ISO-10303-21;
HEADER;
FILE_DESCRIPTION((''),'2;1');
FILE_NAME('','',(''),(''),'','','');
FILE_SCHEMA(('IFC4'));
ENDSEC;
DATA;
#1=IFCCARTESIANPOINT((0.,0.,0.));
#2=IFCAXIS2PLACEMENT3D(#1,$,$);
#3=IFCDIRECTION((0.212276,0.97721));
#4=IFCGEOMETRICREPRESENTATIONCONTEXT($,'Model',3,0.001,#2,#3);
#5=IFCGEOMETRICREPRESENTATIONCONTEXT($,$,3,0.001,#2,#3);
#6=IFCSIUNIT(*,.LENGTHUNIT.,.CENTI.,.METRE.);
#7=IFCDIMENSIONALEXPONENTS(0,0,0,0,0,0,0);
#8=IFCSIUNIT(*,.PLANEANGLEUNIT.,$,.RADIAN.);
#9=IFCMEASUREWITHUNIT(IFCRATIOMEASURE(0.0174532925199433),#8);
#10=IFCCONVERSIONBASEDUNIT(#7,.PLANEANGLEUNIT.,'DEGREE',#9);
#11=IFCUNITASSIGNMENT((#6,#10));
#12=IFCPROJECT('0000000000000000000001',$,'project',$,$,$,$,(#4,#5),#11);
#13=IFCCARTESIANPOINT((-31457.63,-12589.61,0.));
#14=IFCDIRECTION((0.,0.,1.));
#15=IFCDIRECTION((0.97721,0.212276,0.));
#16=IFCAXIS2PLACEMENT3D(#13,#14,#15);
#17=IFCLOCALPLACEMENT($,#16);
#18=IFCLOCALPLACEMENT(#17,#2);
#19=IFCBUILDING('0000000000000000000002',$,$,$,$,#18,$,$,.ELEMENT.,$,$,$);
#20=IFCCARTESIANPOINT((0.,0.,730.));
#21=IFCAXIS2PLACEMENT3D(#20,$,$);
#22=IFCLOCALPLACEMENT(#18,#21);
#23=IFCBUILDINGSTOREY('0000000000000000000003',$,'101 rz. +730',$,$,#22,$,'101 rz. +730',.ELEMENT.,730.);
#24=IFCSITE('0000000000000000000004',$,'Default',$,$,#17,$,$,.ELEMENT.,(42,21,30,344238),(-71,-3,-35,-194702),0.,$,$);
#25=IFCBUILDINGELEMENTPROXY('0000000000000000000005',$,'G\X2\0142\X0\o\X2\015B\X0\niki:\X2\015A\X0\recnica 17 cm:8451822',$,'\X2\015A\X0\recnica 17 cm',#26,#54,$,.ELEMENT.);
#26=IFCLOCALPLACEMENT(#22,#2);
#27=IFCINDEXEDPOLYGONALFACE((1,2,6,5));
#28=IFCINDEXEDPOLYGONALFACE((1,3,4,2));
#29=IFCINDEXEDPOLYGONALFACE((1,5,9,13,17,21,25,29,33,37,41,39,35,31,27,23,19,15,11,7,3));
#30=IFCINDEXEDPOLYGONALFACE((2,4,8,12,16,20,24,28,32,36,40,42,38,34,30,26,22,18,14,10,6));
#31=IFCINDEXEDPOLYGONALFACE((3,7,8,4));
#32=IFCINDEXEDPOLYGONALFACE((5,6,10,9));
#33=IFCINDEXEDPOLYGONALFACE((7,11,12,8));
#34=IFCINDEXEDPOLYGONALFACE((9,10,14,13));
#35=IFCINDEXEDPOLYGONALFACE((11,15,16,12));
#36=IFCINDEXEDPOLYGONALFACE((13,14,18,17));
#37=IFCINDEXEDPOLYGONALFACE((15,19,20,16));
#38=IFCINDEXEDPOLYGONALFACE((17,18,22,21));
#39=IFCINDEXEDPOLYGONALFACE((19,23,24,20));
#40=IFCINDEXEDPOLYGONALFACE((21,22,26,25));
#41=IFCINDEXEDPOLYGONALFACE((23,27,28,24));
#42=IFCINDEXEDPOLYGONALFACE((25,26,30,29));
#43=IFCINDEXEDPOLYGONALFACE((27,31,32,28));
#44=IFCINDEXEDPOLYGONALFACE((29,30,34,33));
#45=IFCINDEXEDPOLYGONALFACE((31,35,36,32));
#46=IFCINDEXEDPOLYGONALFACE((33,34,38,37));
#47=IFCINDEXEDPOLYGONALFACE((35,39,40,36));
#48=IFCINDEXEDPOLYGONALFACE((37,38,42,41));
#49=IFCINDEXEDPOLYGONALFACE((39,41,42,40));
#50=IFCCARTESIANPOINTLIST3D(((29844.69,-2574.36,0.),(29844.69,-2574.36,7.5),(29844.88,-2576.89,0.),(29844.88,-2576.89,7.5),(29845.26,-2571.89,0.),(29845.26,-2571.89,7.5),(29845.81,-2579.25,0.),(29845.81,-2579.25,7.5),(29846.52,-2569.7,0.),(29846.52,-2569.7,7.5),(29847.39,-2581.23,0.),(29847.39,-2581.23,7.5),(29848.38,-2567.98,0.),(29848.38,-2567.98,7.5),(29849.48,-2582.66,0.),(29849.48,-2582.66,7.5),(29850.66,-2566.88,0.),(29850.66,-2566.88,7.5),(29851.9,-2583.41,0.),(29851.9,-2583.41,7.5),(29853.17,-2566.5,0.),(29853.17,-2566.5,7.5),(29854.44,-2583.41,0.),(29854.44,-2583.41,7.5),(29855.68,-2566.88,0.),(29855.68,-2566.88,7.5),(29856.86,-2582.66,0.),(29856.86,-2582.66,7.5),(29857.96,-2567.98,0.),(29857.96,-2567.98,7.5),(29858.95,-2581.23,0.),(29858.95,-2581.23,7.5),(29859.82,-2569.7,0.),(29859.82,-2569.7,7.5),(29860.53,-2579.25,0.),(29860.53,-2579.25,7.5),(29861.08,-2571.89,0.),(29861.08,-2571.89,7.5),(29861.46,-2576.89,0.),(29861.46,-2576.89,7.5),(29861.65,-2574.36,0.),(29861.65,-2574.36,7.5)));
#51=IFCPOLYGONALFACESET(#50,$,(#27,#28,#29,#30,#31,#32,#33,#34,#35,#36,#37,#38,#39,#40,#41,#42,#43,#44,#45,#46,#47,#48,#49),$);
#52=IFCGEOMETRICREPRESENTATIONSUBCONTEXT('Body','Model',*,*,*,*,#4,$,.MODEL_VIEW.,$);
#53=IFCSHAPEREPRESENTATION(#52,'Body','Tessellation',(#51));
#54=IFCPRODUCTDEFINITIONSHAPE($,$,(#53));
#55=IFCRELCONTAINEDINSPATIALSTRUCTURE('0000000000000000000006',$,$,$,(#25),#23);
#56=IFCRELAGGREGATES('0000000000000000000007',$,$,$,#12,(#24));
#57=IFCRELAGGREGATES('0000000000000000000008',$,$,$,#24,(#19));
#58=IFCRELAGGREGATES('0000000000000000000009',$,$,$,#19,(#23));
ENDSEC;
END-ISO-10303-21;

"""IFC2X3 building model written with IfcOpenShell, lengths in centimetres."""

from ifc_helpers import new_model, entity, si_unit, converted_unit, direction, frame, frame_2d, origin, place, context, subcontext, project, spatial, circle, extrude, source, transform, mapped, element, save


model = new_model("IFC2X3")

# Units and contexts
model_context = context("Model", 3, precision=0.001, world=origin(), true_north=direction((0.212276, 0.97721)))
context_of_model = context(None, 3, precision=0.001, world=origin(), true_north=direction((0.212276, 0.97721)))
body_context = subcontext(model_context, "Body", "Model", "MODEL_VIEW")
ifc_project = project(units=[si_unit("LENGTHUNIT", "METRE", prefix="CENTI"), converted_unit("PLANEANGLEUNIT", "DEGREE", entity("IfcRatioMeasure", 0.0174532925199433), si_unit("PLANEANGLEUNIT", "RADIAN"), dimensions=[0, 0, 0, 0, 0, 0, 0])], contexts=[model_context, context_of_model])

# Site, building, storey
site_placement = place(None, frame((-31457.63, -12589.61, 0.0), z_axis=(0.0, 0.0, 1.0), x_axis=(0.97721, 0.212276, 0.0)))
site = spatial("IfcSite", under=ifc_project, at=site_placement, Name="Default", CompositionType="ELEMENT", RefLatitude=(42, 21, 30, 344238), RefLongitude=(-71, -3, -35, -194702), RefElevation=0.0)
building_placement = place(site_placement, origin())
building = spatial("IfcBuilding", under=site, at=building_placement, CompositionType="ELEMENT")
storey_placement = place(building_placement, frame((0.0, 0.0, 730.0)))
storey = spatial("IfcBuildingStorey", under=building, at=storey_placement, Name="101 rz. +730", LongName="101 rz. +730", CompositionType="ELEMENT", Elevation=730.0)

# Building element proxy
shared_shape_1 = source(origin(), body_context, "Body", "SweptSolid", [
    extrude(circle(Radius=8.5, at=frame_2d((0.0, 0.0), x_axis=(1.0, 0.0))), frame((0.0, 0.0, 0.0), z_axis=(0.0, 0.0, 1.0), x_axis=(0.0, 1.0, 0.0)), (0.0, 0.0, 1.0), 7.5),
])
for number, where, name in (
    (1, (29853.17, -2575.0, 0.0), "Głośniki:Śrecnica 17 cm:8451822"),
):
    element("IfcBuildingElementProxy", number, at=place(storey_placement, frame(where)), inside=storey, Name=name, ObjectType="Śrecnica 17 cm", CompositionType="ELEMENT", context=body_context, shape_type="MappedRepresentation", body=[
        mapped(shared_shape_1, transform((0.0, 0.0, 0.0), scale=1.0)),
    ])

save(model, "model.ifc")
